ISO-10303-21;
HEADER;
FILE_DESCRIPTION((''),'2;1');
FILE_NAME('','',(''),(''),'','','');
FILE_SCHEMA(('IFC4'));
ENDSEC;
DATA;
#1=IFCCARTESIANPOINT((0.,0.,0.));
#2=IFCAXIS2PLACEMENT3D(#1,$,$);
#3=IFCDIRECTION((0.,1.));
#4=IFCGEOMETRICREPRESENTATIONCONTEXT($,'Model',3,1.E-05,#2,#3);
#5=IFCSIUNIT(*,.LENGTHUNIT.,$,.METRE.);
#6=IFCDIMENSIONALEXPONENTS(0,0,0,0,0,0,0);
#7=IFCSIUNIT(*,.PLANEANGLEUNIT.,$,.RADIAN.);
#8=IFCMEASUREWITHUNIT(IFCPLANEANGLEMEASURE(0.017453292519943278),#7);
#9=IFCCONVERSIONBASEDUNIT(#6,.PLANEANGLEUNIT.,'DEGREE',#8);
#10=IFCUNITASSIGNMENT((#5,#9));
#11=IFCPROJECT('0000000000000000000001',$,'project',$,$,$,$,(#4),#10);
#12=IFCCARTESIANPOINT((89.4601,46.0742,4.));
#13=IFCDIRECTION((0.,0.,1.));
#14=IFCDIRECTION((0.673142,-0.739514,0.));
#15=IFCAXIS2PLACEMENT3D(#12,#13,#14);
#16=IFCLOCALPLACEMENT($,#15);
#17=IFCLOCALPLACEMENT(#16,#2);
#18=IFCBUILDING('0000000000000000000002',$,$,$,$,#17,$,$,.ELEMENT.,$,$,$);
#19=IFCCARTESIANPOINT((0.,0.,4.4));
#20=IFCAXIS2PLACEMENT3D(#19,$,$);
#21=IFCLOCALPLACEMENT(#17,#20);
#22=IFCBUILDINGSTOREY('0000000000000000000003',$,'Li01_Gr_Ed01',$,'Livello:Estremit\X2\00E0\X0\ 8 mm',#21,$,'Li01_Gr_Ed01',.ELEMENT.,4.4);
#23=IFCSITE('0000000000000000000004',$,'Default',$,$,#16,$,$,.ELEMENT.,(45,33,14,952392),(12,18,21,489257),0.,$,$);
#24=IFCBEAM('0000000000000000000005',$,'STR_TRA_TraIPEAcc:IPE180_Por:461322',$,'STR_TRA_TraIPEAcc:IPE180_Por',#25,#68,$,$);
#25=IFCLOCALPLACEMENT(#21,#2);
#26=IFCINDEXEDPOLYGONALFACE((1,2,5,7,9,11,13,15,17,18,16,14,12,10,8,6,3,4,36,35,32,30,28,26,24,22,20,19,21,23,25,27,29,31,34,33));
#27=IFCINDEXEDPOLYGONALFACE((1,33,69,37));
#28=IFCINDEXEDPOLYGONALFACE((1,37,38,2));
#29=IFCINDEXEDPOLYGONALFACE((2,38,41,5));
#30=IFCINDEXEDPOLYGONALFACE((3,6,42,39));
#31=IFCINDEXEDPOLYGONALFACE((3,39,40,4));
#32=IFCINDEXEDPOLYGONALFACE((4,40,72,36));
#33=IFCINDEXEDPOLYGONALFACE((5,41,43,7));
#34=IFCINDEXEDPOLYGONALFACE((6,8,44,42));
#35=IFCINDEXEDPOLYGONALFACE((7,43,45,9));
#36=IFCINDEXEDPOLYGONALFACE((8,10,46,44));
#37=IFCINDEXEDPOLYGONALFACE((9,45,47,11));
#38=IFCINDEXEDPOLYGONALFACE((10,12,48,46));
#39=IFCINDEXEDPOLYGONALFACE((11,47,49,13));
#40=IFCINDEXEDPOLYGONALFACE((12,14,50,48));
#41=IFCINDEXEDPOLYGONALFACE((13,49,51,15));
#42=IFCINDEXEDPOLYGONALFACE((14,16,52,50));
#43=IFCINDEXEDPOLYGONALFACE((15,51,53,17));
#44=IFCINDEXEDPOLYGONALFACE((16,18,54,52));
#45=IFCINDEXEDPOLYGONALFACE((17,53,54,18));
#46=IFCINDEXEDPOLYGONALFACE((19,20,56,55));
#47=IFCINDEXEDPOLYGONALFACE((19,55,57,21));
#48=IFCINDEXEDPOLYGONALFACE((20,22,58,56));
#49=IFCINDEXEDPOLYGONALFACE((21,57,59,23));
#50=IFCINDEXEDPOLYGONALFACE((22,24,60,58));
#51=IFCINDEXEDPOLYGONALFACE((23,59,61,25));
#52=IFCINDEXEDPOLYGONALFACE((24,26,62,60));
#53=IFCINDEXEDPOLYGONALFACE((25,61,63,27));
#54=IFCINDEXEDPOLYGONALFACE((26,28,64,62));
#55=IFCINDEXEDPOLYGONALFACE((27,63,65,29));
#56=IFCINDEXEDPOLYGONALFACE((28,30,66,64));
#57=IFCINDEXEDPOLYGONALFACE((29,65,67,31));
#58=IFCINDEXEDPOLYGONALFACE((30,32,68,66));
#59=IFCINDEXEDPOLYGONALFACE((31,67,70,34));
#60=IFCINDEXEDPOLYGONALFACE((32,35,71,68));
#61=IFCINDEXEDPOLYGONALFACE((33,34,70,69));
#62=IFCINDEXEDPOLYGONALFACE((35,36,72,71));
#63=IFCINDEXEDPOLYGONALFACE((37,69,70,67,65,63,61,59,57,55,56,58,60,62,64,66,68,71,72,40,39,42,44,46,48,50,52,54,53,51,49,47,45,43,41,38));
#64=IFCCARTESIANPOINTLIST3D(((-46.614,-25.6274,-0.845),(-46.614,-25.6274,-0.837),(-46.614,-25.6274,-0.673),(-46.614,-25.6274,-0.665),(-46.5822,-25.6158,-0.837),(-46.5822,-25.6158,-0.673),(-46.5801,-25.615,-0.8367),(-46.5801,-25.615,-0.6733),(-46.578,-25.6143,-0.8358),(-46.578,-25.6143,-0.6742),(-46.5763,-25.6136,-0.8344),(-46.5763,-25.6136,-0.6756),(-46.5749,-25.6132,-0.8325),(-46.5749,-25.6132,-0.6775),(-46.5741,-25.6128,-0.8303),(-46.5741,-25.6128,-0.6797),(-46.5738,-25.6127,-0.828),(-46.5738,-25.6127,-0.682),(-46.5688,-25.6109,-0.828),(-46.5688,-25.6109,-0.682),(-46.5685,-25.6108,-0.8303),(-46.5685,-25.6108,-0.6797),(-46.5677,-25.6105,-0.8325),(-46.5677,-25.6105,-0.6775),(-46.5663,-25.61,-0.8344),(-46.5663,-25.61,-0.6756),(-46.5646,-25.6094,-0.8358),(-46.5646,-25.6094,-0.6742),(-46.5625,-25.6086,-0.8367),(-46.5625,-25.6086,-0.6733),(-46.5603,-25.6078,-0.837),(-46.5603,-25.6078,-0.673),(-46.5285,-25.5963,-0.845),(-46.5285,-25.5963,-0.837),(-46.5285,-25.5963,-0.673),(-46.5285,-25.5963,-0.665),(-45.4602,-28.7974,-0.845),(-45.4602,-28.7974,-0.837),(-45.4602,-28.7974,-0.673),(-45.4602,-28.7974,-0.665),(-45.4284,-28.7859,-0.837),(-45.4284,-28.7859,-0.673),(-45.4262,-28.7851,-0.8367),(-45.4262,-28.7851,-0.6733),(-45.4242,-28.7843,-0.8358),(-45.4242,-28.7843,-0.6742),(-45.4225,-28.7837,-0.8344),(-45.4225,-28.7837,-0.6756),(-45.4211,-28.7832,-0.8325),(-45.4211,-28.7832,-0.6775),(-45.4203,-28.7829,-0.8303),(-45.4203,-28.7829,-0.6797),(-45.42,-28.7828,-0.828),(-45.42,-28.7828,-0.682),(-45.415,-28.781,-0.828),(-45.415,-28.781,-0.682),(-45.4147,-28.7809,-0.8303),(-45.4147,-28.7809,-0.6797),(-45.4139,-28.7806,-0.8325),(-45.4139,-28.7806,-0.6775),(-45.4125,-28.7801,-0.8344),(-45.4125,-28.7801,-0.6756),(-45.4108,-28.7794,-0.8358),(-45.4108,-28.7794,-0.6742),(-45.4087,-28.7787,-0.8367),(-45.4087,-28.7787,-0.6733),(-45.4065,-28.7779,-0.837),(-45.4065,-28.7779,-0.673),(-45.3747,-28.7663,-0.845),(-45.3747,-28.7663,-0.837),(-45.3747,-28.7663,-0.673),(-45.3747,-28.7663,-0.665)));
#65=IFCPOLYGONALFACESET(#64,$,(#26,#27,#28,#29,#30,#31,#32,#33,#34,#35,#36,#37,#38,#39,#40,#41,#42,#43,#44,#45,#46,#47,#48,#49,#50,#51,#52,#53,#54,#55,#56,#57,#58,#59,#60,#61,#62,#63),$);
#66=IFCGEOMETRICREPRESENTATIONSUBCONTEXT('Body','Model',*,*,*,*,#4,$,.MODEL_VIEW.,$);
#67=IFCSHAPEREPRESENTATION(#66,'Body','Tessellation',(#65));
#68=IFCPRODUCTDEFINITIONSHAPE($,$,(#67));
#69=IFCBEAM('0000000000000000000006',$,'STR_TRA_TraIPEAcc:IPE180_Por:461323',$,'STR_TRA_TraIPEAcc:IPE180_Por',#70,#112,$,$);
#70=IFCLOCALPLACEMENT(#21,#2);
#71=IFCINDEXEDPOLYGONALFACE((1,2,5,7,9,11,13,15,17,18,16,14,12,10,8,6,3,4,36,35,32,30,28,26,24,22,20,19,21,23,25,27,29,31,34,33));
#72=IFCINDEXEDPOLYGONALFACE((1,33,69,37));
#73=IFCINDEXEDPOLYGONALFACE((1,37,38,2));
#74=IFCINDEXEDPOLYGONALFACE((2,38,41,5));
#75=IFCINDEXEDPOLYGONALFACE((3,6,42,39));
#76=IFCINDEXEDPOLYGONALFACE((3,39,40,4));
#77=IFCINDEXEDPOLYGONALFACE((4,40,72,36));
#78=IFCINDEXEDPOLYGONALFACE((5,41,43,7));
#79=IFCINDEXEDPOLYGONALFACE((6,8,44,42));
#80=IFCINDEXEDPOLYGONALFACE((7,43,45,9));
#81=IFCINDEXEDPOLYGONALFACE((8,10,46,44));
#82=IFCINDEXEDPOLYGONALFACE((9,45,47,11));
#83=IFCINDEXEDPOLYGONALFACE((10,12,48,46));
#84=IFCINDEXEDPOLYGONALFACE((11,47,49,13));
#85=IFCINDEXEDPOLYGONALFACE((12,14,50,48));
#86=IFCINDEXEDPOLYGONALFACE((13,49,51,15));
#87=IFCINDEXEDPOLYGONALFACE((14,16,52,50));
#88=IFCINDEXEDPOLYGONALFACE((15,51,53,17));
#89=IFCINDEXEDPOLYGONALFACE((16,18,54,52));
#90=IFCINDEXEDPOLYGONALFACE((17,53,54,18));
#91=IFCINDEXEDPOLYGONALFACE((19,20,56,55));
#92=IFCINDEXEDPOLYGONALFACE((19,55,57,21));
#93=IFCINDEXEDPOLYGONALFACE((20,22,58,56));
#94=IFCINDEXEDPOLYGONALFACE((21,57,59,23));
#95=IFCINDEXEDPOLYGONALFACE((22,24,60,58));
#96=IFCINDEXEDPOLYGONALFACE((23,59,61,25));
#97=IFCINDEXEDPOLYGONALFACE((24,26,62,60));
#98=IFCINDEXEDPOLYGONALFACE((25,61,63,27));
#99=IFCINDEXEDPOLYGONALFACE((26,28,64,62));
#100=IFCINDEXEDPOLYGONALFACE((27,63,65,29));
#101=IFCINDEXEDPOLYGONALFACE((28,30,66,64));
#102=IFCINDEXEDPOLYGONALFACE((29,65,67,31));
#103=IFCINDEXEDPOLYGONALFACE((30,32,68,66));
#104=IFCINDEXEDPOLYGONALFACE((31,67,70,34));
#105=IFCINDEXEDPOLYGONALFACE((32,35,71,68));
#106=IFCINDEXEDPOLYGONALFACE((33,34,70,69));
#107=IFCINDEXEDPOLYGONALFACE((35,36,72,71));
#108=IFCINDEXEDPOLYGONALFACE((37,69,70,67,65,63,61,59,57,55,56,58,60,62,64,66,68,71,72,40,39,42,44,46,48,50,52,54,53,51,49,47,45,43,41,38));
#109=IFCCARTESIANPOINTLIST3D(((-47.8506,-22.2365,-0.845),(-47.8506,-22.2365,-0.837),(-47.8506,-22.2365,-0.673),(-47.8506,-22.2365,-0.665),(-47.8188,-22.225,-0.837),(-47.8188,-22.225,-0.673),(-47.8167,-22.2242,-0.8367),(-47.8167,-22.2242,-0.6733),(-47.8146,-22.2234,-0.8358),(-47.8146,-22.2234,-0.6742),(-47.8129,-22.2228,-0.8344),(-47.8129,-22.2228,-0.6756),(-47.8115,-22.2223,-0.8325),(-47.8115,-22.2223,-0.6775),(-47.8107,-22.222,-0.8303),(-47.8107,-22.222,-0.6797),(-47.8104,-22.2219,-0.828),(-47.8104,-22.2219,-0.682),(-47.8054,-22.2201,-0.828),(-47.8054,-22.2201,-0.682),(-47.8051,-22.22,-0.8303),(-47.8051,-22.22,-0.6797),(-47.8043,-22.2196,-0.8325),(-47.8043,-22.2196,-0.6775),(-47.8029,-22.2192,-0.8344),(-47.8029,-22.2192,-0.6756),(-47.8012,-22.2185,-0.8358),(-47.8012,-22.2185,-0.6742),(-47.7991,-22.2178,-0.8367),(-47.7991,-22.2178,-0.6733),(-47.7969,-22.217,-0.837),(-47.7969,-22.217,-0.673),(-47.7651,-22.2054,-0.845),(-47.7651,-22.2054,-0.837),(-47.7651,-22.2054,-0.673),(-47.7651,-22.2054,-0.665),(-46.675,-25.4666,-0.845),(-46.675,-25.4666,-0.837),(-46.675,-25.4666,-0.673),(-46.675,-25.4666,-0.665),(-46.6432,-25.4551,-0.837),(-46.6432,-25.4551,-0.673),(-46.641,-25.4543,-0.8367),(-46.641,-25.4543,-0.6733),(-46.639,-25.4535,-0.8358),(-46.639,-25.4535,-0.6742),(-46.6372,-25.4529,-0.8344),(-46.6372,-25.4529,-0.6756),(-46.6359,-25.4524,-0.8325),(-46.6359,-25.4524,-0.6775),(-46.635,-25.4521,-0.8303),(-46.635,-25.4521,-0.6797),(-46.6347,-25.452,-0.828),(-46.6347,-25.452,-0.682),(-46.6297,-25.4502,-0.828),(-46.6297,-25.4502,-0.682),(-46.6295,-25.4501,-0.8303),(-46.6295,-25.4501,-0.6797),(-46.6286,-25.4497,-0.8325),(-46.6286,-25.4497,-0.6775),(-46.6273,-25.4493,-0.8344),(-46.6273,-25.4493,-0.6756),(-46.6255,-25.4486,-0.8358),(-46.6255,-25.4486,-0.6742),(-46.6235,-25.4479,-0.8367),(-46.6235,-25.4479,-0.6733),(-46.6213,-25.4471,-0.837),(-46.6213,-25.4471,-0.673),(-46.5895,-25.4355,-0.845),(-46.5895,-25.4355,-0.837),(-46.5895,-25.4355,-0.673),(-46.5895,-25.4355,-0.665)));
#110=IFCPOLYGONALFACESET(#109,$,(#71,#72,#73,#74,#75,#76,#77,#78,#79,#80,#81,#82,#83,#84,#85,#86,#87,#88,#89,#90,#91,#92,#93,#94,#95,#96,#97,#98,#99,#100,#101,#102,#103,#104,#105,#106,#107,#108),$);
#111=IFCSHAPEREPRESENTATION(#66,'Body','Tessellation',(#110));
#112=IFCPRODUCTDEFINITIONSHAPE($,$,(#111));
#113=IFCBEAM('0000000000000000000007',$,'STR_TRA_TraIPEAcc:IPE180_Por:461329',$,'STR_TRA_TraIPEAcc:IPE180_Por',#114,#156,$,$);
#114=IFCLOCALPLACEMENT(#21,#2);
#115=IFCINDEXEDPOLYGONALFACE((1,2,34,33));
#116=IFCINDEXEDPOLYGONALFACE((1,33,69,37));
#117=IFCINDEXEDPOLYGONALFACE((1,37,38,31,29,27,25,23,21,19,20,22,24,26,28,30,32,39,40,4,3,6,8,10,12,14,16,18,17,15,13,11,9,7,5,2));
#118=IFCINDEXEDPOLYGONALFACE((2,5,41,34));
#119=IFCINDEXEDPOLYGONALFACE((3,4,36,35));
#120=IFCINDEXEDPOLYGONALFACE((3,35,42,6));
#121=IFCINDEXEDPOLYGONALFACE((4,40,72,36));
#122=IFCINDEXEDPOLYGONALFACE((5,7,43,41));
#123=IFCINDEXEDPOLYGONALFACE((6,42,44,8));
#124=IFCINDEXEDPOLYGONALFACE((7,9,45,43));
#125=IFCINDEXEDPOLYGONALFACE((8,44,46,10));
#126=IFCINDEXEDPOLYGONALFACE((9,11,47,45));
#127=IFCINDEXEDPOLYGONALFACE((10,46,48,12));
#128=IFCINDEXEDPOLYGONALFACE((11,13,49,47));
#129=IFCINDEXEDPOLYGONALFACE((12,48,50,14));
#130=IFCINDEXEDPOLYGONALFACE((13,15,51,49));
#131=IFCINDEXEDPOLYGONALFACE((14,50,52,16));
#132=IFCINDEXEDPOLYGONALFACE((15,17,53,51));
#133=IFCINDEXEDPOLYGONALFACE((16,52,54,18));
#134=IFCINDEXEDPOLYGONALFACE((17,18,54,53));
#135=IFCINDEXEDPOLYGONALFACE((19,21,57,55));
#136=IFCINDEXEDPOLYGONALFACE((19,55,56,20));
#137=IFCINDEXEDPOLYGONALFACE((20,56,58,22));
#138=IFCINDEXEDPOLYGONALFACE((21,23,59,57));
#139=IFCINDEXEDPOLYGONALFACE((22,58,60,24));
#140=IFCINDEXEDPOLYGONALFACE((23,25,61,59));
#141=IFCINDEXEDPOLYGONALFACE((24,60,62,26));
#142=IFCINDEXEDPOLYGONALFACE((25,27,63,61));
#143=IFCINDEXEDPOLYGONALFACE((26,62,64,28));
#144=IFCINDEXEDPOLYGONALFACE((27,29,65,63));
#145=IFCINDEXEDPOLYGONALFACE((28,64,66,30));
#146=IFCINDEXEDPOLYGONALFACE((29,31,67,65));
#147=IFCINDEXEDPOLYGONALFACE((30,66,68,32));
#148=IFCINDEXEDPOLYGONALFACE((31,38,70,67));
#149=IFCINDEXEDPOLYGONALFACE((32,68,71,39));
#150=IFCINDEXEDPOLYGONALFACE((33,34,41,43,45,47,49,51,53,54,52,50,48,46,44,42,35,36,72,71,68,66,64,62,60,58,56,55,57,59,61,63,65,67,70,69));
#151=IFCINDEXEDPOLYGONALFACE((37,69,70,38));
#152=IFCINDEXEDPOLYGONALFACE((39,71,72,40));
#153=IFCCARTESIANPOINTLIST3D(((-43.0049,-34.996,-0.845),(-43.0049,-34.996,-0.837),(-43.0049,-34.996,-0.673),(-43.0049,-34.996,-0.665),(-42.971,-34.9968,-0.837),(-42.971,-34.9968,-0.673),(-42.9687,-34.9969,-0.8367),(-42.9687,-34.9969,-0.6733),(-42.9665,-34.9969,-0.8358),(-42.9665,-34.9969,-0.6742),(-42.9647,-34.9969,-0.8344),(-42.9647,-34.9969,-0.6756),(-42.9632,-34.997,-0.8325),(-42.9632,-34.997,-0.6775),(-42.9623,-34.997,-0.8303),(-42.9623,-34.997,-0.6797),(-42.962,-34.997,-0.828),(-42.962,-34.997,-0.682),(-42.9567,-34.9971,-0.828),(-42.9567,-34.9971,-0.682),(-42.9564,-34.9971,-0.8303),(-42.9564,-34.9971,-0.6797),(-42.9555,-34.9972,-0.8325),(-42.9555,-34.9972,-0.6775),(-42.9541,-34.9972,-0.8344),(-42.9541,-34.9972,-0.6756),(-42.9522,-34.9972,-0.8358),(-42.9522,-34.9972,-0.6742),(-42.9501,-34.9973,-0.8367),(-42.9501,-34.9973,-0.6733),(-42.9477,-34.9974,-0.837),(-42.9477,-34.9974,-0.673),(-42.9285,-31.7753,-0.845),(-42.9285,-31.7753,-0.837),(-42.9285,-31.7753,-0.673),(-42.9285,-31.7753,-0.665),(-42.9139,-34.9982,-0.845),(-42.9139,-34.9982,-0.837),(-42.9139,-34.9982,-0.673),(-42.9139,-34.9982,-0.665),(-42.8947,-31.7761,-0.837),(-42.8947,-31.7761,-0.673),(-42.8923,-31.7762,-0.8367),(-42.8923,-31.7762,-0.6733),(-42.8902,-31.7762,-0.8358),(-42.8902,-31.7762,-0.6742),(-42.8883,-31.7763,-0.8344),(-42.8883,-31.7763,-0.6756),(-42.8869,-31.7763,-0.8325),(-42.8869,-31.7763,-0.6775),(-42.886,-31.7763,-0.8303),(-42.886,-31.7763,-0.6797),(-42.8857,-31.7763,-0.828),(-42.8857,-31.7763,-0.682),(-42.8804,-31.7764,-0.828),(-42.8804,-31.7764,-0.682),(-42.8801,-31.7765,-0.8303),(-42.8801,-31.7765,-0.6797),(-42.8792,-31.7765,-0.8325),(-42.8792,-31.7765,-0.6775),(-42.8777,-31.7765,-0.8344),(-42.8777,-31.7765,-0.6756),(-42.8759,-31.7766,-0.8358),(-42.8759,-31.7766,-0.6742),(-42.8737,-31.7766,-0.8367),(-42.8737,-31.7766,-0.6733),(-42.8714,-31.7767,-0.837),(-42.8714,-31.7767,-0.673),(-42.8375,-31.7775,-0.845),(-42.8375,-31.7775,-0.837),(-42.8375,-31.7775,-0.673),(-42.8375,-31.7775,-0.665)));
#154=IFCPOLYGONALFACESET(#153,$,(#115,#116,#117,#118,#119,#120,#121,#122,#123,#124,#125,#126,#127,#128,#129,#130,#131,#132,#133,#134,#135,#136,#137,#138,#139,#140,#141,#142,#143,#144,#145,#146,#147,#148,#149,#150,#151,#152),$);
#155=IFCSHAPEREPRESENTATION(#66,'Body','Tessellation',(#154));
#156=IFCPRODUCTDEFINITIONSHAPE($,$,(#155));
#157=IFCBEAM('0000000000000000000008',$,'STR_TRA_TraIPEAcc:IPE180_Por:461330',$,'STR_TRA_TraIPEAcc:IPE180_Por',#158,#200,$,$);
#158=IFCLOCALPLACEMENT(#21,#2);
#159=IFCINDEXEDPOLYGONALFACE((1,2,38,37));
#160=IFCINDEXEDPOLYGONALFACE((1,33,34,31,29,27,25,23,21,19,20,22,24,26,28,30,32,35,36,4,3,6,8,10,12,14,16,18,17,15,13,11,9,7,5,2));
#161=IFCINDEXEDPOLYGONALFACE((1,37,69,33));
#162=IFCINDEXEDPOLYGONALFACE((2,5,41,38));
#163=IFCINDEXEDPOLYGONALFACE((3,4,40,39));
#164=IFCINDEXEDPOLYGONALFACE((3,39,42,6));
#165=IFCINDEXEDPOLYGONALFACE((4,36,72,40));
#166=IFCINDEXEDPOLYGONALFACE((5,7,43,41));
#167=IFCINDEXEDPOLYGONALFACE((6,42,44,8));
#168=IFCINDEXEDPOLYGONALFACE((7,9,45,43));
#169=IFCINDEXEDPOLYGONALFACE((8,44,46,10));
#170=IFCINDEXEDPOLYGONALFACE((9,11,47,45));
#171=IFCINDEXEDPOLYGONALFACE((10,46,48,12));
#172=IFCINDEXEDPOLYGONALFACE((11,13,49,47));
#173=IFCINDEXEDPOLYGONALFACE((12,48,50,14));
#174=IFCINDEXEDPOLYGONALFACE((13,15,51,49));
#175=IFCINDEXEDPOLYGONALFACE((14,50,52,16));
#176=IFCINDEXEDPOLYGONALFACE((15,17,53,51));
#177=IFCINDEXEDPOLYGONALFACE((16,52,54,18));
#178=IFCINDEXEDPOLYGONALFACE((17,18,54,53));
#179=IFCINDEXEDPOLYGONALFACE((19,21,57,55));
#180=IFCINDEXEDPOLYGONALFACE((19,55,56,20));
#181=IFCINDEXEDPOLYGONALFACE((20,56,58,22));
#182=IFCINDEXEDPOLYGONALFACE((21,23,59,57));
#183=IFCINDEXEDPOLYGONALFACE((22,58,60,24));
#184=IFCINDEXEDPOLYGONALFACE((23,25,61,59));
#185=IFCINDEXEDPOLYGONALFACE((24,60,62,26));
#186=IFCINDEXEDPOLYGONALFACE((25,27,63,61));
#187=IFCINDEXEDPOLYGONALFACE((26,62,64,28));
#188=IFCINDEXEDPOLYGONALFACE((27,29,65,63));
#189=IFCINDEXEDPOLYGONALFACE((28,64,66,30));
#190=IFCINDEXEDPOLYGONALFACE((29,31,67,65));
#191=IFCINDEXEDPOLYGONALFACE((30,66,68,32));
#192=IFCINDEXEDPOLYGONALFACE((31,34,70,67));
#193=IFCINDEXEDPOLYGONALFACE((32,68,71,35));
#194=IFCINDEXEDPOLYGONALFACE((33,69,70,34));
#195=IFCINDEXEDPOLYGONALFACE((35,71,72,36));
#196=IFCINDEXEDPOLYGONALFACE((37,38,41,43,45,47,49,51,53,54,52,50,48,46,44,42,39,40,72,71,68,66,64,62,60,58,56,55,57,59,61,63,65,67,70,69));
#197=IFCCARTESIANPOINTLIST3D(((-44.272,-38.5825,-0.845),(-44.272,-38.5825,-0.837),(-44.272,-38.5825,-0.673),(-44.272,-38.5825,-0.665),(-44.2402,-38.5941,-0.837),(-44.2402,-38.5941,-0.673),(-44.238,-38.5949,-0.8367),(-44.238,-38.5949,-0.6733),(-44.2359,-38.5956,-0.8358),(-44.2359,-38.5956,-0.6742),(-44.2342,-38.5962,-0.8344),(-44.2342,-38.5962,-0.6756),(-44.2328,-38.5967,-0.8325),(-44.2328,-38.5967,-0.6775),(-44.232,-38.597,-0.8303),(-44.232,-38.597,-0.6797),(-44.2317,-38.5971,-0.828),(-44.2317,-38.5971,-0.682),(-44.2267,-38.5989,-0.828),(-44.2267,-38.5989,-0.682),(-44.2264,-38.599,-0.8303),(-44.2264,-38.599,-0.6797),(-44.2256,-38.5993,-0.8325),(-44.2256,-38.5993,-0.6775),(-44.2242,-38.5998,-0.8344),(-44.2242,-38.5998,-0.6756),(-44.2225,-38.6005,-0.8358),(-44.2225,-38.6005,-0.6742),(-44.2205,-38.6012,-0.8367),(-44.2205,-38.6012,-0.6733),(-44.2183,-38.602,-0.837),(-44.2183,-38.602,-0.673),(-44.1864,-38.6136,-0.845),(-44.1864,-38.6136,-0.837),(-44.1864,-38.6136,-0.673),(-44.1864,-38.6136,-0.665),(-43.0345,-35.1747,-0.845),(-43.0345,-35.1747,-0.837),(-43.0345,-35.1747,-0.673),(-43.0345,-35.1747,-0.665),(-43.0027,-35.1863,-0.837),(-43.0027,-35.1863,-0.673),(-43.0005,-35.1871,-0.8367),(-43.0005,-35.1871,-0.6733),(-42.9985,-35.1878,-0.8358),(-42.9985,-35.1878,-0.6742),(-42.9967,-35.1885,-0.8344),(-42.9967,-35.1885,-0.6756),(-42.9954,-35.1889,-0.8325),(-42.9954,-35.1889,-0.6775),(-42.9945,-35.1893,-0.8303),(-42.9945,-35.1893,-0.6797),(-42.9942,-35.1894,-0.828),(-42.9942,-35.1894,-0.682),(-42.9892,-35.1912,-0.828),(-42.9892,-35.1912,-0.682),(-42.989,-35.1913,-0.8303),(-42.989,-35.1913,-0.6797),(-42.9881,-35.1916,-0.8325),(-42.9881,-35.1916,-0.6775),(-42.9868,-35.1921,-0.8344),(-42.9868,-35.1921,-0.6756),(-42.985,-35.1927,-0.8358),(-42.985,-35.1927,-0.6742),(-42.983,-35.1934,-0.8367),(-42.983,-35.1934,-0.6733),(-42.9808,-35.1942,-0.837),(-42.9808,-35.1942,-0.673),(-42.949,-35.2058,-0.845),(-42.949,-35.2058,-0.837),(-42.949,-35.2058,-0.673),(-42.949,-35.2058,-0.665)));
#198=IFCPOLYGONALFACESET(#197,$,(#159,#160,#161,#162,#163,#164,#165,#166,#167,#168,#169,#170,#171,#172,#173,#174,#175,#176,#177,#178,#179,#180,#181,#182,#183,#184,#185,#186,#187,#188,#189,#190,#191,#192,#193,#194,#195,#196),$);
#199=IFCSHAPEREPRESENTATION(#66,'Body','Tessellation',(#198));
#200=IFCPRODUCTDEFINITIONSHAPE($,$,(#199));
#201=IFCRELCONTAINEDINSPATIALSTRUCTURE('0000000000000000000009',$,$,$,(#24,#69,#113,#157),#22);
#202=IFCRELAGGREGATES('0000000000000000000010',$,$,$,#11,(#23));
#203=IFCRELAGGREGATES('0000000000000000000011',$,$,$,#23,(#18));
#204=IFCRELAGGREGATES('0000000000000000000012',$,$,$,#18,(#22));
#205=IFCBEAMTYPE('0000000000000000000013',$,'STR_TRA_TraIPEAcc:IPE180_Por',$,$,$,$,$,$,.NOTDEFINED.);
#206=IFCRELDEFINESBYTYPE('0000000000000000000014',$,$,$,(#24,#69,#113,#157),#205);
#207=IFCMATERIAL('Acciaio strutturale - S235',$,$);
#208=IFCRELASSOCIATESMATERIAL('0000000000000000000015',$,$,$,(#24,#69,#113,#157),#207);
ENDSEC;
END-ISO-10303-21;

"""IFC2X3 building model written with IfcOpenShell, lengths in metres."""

from ifc_helpers import new_model, entity, si_unit, converted_unit, direction, frame, frame_2d, origin, place, context, subcontext, project, spatial, i_section, extrude, material, type_object, element, save


model = new_model("IFC2X3")

# Units and contexts
model_context = context("Model", 3, precision=1e-05, world=origin(), true_north=direction((0.0, 1.0)))
body_context = subcontext(model_context, "Body", "Model", "MODEL_VIEW")
ifc_project = project(units=[si_unit("LENGTHUNIT", "METRE"), converted_unit("PLANEANGLEUNIT", "DEGREE", entity("IfcPlaneAngleMeasure", 0.017453292519943278), si_unit("PLANEANGLEUNIT", "RADIAN"), dimensions=[0, 0, 0, 0, 0, 0, 0])], contexts=[model_context])

# Site, building, storey
site_placement = place(None, frame((89.4601, 46.0742, 4.0), z_axis=(0.0, 0.0, 1.0), x_axis=(0.673142, -0.739514, 0.0)))
site = spatial("IfcSite", under=ifc_project, at=site_placement, Name="Default", CompositionType="ELEMENT", RefLatitude=(45, 33, 14, 952392), RefLongitude=(12, 18, 21, 489257), RefElevation=0.0)
building_placement = place(site_placement, origin())
building = spatial("IfcBuilding", under=site, at=building_placement, CompositionType="ELEMENT")
storey_placement = place(building_placement, frame((0.0, 0.0, 4.4)))
storey = spatial("IfcBuildingStorey", under=building, at=storey_placement, Name="Li01_Gr_Ed01", ObjectType="Livello:Estremità 8 mm", LongName="Li01_Gr_Ed01", CompositionType="ELEMENT", Elevation=4.4)

# Beams
ifc_material_1 = material(Name="Acciaio strutturale - S235")
beam_type = type_object("IfcBeamType", Name="STR_TRA_TraIPEAcc:IPE180_Por", PredefinedType="NOTDEFINED")
beam_1_placement = place(storey_placement, frame((-45.4099, -28.8029, -0.665), z_axis=(0.0, 0.0, 1.0), x_axis=(-0.34202, 0.939693, 0.0)))
element("IfcBeam", 1, at=beam_1_placement, inside=storey, type_object=beam_type, material=ifc_material_1, Name="STR_TRA_TraIPEAcc:IPE180_Por:461322", ObjectType="STR_TRA_TraIPEAcc:IPE180_Por", context=body_context, shape_type="SweptSolid", body=[
    extrude(i_section(OverallWidth=0.091, OverallDepth=0.18, WebThickness=0.0053, FlangeThickness=0.008, FilletRadius=0.009, at=frame_2d((0.0, 0.0), x_axis=(0.0, 1.0))), frame((0.0223, 0.0, -0.09), z_axis=(1.0, 0.0, 0.0), x_axis=(0.0, 0.0, -1.0)), (0.0, 0.0, 1.0), 3.3735),
])
beam_2_placement = place(storey_placement, frame((-46.6021, -25.5339, -0.665), z_axis=(0.0, 0.0, 1.0), x_axis=(-0.34202, 0.939693, 0.0)))
element("IfcBeam", 2, at=beam_2_placement, inside=storey, type_object=beam_type, material=ifc_material_1, Name="STR_TRA_TraIPEAcc:IPE180_Por:461323", ObjectType="STR_TRA_TraIPEAcc:IPE180_Por", context=body_context, shape_type="SweptSolid", body=[
    extrude(i_section(OverallWidth=0.091, OverallDepth=0.18, WebThickness=0.0053, FlangeThickness=0.008, FilletRadius=0.009, at=frame_2d((0.0, 0.0), x_axis=(0.0, 1.0))), frame((0.0881, 0.0, -0.09), z_axis=(1.0, 0.0, 0.0), x_axis=(0.0, 0.0, -1.0)), (0.0, 0.0, 1.0), 3.4374),
])
beam_3_placement = place(storey_placement, frame((-42.8804, -31.6676, -0.665), z_axis=(0.0, 0.0, 1.0), x_axis=(-0.023708, -0.999719, 0.0)))
element("IfcBeam", 3, at=beam_3_placement, inside=storey, type_object=beam_type, material=ifc_material_1, Name="STR_TRA_TraIPEAcc:IPE180_Por:461329", ObjectType="STR_TRA_TraIPEAcc:IPE180_Por", context=body_context, shape_type="SweptSolid", body=[
    extrude(i_section(OverallWidth=0.091, OverallDepth=0.18, WebThickness=0.0053, FlangeThickness=0.008, FilletRadius=0.009, at=frame_2d((0.0, 0.0), x_axis=(0.0, 1.0))), frame((0.1088, 0.0, -0.09), z_axis=(1.0, 0.0, 0.0), x_axis=(0.0, 0.0, -1.0)), (0.0, 0.0, 1.0), 3.2216),
])
beam_4_placement = place(storey_placement, frame((-42.962, -35.1084, -0.665), z_axis=(0.0, 0.0, 1.0), x_axis=(-0.341327, -0.939945, 0.0)))
element("IfcBeam", 4, at=beam_4_placement, inside=storey, type_object=beam_type, material=ifc_material_1, Name="STR_TRA_TraIPEAcc:IPE180_Por:461330", ObjectType="STR_TRA_TraIPEAcc:IPE180_Por", context=body_context, shape_type="SweptSolid", body=[
    extrude(i_section(OverallWidth=0.091, OverallDepth=0.18, WebThickness=0.0053, FlangeThickness=0.008, FilletRadius=0.009, at=frame_2d((0.0, 0.0), x_axis=(0.0, 1.0))), frame((0.087, 0.0, -0.09), z_axis=(1.0, 0.0, 0.0), x_axis=(0.0, 0.0, -1.0)), (0.0, 0.0, 1.0), 3.6255),
])

save(model, "model.ifc")
